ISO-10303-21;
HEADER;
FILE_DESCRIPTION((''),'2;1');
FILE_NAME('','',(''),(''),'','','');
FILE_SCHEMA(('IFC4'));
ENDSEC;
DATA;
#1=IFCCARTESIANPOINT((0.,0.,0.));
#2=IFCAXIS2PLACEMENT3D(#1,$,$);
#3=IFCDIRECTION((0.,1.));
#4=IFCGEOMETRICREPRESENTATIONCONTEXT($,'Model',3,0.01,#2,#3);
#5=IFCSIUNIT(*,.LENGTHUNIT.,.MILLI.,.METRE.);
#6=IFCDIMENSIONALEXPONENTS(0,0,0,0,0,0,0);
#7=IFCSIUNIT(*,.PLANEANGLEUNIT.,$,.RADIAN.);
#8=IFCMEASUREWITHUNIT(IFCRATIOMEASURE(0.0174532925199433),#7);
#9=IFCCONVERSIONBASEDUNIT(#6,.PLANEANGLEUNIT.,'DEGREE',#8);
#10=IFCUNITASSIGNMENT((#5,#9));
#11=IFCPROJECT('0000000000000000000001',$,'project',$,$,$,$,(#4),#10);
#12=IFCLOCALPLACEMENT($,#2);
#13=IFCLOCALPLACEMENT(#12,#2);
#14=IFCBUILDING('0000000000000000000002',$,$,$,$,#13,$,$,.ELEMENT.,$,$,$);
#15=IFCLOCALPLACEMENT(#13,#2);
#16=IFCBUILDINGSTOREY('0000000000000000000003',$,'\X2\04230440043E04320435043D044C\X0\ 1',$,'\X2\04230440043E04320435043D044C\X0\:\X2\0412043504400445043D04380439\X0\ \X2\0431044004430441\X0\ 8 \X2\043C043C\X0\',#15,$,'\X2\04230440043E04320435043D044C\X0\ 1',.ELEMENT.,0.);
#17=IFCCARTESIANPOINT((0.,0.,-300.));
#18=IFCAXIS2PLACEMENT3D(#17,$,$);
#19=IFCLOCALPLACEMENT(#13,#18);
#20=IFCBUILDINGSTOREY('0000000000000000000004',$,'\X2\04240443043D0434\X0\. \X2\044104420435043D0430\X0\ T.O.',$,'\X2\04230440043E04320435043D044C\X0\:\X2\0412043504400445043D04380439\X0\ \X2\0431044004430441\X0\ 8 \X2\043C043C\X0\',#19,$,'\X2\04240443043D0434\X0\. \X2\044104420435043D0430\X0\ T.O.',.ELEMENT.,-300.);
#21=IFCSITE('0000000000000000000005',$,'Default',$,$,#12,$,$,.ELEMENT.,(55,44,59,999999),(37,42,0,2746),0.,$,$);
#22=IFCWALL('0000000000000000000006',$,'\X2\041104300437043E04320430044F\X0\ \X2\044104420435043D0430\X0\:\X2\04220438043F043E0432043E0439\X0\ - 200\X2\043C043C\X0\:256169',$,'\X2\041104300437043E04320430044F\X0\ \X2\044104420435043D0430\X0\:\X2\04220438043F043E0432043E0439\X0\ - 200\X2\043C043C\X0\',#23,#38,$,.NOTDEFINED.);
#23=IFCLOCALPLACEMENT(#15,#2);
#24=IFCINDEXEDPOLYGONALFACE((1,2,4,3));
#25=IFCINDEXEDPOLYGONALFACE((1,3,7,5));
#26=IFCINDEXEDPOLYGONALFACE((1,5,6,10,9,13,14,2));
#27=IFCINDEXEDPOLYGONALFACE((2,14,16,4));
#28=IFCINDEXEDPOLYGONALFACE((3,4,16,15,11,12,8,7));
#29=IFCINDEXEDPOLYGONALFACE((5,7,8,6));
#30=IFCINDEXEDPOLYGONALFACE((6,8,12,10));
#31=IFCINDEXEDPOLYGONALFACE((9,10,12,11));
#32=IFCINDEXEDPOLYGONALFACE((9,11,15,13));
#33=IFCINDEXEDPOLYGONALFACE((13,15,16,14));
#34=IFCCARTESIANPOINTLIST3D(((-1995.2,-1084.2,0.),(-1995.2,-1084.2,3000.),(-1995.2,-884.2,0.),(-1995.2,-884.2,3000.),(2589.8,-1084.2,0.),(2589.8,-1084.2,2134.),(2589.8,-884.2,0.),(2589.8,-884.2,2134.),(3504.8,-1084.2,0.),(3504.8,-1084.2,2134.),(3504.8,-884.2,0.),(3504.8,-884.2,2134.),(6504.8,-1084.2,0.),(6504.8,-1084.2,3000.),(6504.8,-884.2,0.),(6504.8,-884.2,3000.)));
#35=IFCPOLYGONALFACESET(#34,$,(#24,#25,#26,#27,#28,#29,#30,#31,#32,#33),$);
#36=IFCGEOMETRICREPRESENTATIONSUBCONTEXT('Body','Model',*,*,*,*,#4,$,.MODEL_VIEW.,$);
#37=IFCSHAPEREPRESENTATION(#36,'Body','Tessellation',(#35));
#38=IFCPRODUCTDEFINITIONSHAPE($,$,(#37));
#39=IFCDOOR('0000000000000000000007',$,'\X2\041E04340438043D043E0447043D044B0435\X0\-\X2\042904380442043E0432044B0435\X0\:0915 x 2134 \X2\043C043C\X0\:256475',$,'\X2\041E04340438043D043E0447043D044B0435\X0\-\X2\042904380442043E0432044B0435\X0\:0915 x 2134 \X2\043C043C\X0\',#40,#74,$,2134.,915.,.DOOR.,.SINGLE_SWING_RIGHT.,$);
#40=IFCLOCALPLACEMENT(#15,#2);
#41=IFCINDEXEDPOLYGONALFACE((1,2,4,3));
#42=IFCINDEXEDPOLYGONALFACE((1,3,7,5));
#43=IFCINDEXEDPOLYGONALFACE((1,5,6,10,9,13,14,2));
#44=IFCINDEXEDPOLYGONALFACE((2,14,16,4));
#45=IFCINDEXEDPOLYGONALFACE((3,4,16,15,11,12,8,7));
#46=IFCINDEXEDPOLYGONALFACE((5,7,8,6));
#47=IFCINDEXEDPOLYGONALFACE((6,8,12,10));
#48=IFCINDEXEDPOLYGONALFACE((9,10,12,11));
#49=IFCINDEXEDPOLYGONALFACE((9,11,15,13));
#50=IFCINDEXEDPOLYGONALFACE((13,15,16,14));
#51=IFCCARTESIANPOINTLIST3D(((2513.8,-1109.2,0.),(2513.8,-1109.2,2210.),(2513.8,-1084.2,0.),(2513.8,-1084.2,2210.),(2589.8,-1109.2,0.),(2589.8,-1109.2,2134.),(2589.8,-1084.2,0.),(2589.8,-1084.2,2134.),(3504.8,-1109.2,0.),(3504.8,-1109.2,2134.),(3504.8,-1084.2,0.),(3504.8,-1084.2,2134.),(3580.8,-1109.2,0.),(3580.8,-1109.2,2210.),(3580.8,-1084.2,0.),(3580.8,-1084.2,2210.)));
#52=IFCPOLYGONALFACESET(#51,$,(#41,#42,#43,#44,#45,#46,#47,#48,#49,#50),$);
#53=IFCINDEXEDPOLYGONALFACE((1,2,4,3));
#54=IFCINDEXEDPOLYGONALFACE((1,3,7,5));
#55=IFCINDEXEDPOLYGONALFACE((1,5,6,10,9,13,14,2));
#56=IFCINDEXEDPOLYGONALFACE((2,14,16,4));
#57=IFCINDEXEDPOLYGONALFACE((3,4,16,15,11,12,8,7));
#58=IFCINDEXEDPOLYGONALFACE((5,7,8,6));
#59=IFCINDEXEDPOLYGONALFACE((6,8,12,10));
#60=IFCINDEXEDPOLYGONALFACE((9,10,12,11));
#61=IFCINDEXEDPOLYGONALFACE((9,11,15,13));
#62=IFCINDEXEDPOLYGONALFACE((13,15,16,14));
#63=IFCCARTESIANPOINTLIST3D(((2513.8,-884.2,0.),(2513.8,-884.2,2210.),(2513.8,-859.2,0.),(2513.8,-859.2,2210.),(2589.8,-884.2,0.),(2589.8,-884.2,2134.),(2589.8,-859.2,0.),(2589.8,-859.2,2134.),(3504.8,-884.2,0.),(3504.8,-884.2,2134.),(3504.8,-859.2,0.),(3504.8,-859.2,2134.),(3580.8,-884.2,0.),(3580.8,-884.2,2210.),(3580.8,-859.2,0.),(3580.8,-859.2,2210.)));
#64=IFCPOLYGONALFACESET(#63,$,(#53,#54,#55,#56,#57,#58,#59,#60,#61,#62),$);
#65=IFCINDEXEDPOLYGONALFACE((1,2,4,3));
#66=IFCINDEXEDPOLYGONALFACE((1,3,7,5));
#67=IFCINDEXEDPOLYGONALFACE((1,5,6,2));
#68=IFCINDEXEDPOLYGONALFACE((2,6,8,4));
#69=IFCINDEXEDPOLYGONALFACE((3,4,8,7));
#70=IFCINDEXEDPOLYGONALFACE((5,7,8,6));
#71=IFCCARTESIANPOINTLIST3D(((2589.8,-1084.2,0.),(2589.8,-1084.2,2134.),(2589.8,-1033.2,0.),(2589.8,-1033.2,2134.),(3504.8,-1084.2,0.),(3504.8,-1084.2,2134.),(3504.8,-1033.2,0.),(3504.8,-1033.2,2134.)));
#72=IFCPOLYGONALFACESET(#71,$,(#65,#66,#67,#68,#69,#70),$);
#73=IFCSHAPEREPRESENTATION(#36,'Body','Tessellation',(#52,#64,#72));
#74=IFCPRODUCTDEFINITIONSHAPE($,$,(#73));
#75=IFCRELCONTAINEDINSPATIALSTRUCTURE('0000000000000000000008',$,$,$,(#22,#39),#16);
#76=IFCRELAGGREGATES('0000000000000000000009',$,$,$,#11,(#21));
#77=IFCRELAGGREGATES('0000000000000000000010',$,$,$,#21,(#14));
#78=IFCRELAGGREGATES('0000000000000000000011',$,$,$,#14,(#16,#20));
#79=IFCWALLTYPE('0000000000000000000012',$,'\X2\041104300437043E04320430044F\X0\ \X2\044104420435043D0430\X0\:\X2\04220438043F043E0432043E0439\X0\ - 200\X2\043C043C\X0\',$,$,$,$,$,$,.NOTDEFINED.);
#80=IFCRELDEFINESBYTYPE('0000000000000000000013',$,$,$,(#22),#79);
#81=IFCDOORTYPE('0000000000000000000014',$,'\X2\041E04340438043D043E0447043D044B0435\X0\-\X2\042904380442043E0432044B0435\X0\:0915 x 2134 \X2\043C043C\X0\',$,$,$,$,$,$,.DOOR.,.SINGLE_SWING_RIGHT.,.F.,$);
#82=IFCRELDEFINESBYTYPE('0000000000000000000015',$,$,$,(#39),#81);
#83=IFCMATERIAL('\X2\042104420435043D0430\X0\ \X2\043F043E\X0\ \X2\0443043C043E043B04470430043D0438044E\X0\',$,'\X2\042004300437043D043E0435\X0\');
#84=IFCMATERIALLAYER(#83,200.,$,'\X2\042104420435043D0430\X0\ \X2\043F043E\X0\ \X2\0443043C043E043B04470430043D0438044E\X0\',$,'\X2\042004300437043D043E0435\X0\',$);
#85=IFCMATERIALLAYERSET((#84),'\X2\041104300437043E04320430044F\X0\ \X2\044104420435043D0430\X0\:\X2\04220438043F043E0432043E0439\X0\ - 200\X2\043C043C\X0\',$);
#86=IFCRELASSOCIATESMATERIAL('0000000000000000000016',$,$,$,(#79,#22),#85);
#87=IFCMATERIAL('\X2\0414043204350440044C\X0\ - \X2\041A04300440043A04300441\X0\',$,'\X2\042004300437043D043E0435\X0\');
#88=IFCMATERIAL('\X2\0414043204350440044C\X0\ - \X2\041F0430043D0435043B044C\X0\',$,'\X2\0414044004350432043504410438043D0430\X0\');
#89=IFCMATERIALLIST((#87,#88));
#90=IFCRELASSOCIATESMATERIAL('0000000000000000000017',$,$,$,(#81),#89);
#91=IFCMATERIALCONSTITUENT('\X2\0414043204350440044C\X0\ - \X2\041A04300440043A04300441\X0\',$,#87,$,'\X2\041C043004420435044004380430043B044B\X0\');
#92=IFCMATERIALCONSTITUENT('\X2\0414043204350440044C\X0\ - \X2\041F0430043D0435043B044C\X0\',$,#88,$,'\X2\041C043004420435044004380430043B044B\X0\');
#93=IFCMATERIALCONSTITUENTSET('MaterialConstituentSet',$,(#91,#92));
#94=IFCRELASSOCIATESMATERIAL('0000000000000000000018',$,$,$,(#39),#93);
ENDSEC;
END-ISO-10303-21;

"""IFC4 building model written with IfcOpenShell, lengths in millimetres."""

from ifc_helpers import new_model, entity, si_unit, converted_unit, direction, frame, frame_2d, origin, place, context, subcontext, project, spatial, polyline, rectangle, outline, extrude, source, transform, mapped, material, material_list, layer, layer_set, layer_usage, constituent, constituent_set, type_object, type_shapes, element, fill, save


model = new_model("IFC4")

# Units and contexts
model_context = context("Model", 3, precision=0.01, world=origin(), true_north=direction((0.0, 1.0)))
body_context = subcontext(model_context, "Body", "Model", "MODEL_VIEW")
ifc_project = project(units=[si_unit("LENGTHUNIT", "METRE", prefix="MILLI"), converted_unit("PLANEANGLEUNIT", "DEGREE", entity("IfcRatioMeasure", 0.0174532925199433), si_unit("PLANEANGLEUNIT", "RADIAN"), dimensions=[0, 0, 0, 0, 0, 0, 0])], contexts=[model_context])

# Site, building, storey
site_placement = place(None, origin())
site = spatial("IfcSite", under=ifc_project, at=site_placement, Name="Default", CompositionType="ELEMENT", RefLatitude=(55, 44, 59, 999999), RefLongitude=(37, 42, 0, 2746), RefElevation=0.0)
building_placement = place(site_placement, origin())
building = spatial("IfcBuilding", under=site, at=building_placement, CompositionType="ELEMENT")
storey_1_placement = place(building_placement, origin())
storey_1 = spatial("IfcBuildingStorey", under=building, at=storey_1_placement, Name="Уровень 1", ObjectType="Уровень:Верхний брус 8 мм", LongName="Уровень 1", CompositionType="ELEMENT", Elevation=0.0)

# Shared definitions
ifc_material_1 = material(Name="Стена по умолчанию", Category="Разное")
ifc_layer = layer(ifc_material_1, 200.0, Name="Стена по умолчанию", Category="Разное")
ifc_layer_set = layer_set([ifc_layer], Name="Базовая стена:Типовой - 200мм")
wall_type = type_object("IfcWallType", Name="Базовая стена:Типовой - 200мм", PredefinedType="NOTDEFINED", material=ifc_layer_set)

# Wall, opening, door
ifc_layer_usage_1 = layer_usage(ifc_layer_set, "AXIS2", "NEGATIVE", 100.0)
wall_1_placement = place(storey_1_placement, frame((6504.8, -984.2, 0.0), z_axis=(0.0, 0.0, 1.0), x_axis=(-1.0, 0.0, 0.0)))
wall_1 = element("IfcWall", 1, at=wall_1_placement, inside=storey_1, type_object=wall_type, material=ifc_layer_usage_1, Name="Базовая стена:Типовой - 200мм:256169", ObjectType="Базовая стена:Типовой - 200мм", PredefinedType="NOTDEFINED", context=body_context, shape_type="SweptSolid", body=[
    extrude(rectangle(XDim=8500.0, YDim=200.0, at=frame_2d((4250.0, 0.0), x_axis=(-1.0, 0.0))), origin(), (0.0, 0.0, 1.0), 3000.0),
])
opening_1_placement = place(wall_1_placement, frame((3000.0, -100.0, 0.0)))
opening_1 = element("IfcOpeningElement", 2, at=opening_1_placement, cuts=wall_1, ObjectType="Opening", PredefinedType="OPENING", context=body_context, shape_type="SweptSolid", body=[
    extrude(rectangle(XDim=915.0, YDim=2134.0, at=frame_2d((1067.0, 457.5), x_axis=(0.0, 1.0))), frame((0.0, 0.0, 0.0), z_axis=(0.0, 1.0, 0.0), x_axis=(0.0, 0.0, 1.0)), (0.0, 0.0, 1.0), 200.0),
])
ifc_material_2 = material(Name="Дверь - Каркас", Category="Разное")
ifc_constituent_1 = constituent(ifc_material_2, Name="Дверь - Каркас", Category="Материалы")
ifc_material_3 = material(Name="Дверь - Панель", Category="Древесина")
ifc_constituent_2 = constituent(ifc_material_3, Name="Дверь - Панель", Category="Материалы")
ifc_constituent_set_1 = constituent_set(constituents=[ifc_constituent_1, ifc_constituent_2], Name="MaterialConstituentSet")
ifc_material_list_1 = material_list([ifc_material_2, ifc_material_3])
door_type = type_object("IfcDoorType", Name="Одиночные-Щитовые:0915 x 2134 мм", OperationType="SINGLE_SWING_RIGHT", ParameterTakesPrecedence=False, PredefinedType="DOOR", material=ifc_material_list_1)
shared_shape_1 = source(origin(), body_context, "Body", "SweptSolid", [
    extrude(outline(polyline([(-533.5, -1124.0), (533.5, -1124.0), (533.5, 1086.0), (457.5, 1086.0), (457.5, -1048.0), (-457.5, -1048.0), (-457.5, 1086.0), (-533.5, 1086.0), (-533.5, -1124.0)])), frame((457.5, 200.0, 1086.0), z_axis=(0.0, 1.0, 0.0), x_axis=(1.0, 0.0, 0.0)), (0.0, 0.0, 1.0), 25.0),
    extrude(outline(polyline([(-1124.0, -533.5), (1086.0, -533.5), (1086.0, -457.5), (-1048.0, -457.5), (-1048.0, 457.5), (1086.0, 457.5), (1086.0, 533.5), (-1124.0, 533.5), (-1124.0, -533.5)])), frame((457.5, -25.0, 1086.0), z_axis=(0.0, 1.0, 0.0), x_axis=(0.0, 0.0, -1.0)), (0.0, 0.0, 1.0), 25.0),
    extrude(rectangle(XDim=51.0, YDim=915.0, at=frame_2d((0.0, 0.0), x_axis=(1.0, 0.0))), frame((457.5, 174.5, 0.0), z_axis=(0.0, 0.0, 1.0), x_axis=(0.0, 1.0, 0.0)), (0.0, 0.0, 1.0), 2134.0),
])
type_shapes(door_type, [shared_shape_1])
door_1_placement = place(opening_1_placement, origin())
door_1 = element("IfcDoor", 3, at=door_1_placement, inside=storey_1, type_object=door_type, material=ifc_constituent_set_1, Name="Одиночные-Щитовые:0915 x 2134 мм:256475", ObjectType="Одиночные-Щитовые:0915 x 2134 мм", OperationType="SINGLE_SWING_RIGHT", OverallHeight=2134.0, OverallWidth=915.0, PredefinedType="DOOR", context=body_context, shape_type="MappedRepresentation", body=[
    mapped(shared_shape_1, transform((0.0, 0.0, 0.0), scale=1.0)),
])
fill(opening_1, door_1)

# Shared definitions
storey_2_placement = place(building_placement, frame((0.0, 0.0, -300.0)))
storey_2 = spatial("IfcBuildingStorey", under=building, at=storey_2_placement, Name="Фунд. стена T.O.", ObjectType="Уровень:Верхний брус 8 мм", LongName="Фунд. стена T.O.", CompositionType="ELEMENT", Elevation=-300.0)

save(model, "model.ifc")
